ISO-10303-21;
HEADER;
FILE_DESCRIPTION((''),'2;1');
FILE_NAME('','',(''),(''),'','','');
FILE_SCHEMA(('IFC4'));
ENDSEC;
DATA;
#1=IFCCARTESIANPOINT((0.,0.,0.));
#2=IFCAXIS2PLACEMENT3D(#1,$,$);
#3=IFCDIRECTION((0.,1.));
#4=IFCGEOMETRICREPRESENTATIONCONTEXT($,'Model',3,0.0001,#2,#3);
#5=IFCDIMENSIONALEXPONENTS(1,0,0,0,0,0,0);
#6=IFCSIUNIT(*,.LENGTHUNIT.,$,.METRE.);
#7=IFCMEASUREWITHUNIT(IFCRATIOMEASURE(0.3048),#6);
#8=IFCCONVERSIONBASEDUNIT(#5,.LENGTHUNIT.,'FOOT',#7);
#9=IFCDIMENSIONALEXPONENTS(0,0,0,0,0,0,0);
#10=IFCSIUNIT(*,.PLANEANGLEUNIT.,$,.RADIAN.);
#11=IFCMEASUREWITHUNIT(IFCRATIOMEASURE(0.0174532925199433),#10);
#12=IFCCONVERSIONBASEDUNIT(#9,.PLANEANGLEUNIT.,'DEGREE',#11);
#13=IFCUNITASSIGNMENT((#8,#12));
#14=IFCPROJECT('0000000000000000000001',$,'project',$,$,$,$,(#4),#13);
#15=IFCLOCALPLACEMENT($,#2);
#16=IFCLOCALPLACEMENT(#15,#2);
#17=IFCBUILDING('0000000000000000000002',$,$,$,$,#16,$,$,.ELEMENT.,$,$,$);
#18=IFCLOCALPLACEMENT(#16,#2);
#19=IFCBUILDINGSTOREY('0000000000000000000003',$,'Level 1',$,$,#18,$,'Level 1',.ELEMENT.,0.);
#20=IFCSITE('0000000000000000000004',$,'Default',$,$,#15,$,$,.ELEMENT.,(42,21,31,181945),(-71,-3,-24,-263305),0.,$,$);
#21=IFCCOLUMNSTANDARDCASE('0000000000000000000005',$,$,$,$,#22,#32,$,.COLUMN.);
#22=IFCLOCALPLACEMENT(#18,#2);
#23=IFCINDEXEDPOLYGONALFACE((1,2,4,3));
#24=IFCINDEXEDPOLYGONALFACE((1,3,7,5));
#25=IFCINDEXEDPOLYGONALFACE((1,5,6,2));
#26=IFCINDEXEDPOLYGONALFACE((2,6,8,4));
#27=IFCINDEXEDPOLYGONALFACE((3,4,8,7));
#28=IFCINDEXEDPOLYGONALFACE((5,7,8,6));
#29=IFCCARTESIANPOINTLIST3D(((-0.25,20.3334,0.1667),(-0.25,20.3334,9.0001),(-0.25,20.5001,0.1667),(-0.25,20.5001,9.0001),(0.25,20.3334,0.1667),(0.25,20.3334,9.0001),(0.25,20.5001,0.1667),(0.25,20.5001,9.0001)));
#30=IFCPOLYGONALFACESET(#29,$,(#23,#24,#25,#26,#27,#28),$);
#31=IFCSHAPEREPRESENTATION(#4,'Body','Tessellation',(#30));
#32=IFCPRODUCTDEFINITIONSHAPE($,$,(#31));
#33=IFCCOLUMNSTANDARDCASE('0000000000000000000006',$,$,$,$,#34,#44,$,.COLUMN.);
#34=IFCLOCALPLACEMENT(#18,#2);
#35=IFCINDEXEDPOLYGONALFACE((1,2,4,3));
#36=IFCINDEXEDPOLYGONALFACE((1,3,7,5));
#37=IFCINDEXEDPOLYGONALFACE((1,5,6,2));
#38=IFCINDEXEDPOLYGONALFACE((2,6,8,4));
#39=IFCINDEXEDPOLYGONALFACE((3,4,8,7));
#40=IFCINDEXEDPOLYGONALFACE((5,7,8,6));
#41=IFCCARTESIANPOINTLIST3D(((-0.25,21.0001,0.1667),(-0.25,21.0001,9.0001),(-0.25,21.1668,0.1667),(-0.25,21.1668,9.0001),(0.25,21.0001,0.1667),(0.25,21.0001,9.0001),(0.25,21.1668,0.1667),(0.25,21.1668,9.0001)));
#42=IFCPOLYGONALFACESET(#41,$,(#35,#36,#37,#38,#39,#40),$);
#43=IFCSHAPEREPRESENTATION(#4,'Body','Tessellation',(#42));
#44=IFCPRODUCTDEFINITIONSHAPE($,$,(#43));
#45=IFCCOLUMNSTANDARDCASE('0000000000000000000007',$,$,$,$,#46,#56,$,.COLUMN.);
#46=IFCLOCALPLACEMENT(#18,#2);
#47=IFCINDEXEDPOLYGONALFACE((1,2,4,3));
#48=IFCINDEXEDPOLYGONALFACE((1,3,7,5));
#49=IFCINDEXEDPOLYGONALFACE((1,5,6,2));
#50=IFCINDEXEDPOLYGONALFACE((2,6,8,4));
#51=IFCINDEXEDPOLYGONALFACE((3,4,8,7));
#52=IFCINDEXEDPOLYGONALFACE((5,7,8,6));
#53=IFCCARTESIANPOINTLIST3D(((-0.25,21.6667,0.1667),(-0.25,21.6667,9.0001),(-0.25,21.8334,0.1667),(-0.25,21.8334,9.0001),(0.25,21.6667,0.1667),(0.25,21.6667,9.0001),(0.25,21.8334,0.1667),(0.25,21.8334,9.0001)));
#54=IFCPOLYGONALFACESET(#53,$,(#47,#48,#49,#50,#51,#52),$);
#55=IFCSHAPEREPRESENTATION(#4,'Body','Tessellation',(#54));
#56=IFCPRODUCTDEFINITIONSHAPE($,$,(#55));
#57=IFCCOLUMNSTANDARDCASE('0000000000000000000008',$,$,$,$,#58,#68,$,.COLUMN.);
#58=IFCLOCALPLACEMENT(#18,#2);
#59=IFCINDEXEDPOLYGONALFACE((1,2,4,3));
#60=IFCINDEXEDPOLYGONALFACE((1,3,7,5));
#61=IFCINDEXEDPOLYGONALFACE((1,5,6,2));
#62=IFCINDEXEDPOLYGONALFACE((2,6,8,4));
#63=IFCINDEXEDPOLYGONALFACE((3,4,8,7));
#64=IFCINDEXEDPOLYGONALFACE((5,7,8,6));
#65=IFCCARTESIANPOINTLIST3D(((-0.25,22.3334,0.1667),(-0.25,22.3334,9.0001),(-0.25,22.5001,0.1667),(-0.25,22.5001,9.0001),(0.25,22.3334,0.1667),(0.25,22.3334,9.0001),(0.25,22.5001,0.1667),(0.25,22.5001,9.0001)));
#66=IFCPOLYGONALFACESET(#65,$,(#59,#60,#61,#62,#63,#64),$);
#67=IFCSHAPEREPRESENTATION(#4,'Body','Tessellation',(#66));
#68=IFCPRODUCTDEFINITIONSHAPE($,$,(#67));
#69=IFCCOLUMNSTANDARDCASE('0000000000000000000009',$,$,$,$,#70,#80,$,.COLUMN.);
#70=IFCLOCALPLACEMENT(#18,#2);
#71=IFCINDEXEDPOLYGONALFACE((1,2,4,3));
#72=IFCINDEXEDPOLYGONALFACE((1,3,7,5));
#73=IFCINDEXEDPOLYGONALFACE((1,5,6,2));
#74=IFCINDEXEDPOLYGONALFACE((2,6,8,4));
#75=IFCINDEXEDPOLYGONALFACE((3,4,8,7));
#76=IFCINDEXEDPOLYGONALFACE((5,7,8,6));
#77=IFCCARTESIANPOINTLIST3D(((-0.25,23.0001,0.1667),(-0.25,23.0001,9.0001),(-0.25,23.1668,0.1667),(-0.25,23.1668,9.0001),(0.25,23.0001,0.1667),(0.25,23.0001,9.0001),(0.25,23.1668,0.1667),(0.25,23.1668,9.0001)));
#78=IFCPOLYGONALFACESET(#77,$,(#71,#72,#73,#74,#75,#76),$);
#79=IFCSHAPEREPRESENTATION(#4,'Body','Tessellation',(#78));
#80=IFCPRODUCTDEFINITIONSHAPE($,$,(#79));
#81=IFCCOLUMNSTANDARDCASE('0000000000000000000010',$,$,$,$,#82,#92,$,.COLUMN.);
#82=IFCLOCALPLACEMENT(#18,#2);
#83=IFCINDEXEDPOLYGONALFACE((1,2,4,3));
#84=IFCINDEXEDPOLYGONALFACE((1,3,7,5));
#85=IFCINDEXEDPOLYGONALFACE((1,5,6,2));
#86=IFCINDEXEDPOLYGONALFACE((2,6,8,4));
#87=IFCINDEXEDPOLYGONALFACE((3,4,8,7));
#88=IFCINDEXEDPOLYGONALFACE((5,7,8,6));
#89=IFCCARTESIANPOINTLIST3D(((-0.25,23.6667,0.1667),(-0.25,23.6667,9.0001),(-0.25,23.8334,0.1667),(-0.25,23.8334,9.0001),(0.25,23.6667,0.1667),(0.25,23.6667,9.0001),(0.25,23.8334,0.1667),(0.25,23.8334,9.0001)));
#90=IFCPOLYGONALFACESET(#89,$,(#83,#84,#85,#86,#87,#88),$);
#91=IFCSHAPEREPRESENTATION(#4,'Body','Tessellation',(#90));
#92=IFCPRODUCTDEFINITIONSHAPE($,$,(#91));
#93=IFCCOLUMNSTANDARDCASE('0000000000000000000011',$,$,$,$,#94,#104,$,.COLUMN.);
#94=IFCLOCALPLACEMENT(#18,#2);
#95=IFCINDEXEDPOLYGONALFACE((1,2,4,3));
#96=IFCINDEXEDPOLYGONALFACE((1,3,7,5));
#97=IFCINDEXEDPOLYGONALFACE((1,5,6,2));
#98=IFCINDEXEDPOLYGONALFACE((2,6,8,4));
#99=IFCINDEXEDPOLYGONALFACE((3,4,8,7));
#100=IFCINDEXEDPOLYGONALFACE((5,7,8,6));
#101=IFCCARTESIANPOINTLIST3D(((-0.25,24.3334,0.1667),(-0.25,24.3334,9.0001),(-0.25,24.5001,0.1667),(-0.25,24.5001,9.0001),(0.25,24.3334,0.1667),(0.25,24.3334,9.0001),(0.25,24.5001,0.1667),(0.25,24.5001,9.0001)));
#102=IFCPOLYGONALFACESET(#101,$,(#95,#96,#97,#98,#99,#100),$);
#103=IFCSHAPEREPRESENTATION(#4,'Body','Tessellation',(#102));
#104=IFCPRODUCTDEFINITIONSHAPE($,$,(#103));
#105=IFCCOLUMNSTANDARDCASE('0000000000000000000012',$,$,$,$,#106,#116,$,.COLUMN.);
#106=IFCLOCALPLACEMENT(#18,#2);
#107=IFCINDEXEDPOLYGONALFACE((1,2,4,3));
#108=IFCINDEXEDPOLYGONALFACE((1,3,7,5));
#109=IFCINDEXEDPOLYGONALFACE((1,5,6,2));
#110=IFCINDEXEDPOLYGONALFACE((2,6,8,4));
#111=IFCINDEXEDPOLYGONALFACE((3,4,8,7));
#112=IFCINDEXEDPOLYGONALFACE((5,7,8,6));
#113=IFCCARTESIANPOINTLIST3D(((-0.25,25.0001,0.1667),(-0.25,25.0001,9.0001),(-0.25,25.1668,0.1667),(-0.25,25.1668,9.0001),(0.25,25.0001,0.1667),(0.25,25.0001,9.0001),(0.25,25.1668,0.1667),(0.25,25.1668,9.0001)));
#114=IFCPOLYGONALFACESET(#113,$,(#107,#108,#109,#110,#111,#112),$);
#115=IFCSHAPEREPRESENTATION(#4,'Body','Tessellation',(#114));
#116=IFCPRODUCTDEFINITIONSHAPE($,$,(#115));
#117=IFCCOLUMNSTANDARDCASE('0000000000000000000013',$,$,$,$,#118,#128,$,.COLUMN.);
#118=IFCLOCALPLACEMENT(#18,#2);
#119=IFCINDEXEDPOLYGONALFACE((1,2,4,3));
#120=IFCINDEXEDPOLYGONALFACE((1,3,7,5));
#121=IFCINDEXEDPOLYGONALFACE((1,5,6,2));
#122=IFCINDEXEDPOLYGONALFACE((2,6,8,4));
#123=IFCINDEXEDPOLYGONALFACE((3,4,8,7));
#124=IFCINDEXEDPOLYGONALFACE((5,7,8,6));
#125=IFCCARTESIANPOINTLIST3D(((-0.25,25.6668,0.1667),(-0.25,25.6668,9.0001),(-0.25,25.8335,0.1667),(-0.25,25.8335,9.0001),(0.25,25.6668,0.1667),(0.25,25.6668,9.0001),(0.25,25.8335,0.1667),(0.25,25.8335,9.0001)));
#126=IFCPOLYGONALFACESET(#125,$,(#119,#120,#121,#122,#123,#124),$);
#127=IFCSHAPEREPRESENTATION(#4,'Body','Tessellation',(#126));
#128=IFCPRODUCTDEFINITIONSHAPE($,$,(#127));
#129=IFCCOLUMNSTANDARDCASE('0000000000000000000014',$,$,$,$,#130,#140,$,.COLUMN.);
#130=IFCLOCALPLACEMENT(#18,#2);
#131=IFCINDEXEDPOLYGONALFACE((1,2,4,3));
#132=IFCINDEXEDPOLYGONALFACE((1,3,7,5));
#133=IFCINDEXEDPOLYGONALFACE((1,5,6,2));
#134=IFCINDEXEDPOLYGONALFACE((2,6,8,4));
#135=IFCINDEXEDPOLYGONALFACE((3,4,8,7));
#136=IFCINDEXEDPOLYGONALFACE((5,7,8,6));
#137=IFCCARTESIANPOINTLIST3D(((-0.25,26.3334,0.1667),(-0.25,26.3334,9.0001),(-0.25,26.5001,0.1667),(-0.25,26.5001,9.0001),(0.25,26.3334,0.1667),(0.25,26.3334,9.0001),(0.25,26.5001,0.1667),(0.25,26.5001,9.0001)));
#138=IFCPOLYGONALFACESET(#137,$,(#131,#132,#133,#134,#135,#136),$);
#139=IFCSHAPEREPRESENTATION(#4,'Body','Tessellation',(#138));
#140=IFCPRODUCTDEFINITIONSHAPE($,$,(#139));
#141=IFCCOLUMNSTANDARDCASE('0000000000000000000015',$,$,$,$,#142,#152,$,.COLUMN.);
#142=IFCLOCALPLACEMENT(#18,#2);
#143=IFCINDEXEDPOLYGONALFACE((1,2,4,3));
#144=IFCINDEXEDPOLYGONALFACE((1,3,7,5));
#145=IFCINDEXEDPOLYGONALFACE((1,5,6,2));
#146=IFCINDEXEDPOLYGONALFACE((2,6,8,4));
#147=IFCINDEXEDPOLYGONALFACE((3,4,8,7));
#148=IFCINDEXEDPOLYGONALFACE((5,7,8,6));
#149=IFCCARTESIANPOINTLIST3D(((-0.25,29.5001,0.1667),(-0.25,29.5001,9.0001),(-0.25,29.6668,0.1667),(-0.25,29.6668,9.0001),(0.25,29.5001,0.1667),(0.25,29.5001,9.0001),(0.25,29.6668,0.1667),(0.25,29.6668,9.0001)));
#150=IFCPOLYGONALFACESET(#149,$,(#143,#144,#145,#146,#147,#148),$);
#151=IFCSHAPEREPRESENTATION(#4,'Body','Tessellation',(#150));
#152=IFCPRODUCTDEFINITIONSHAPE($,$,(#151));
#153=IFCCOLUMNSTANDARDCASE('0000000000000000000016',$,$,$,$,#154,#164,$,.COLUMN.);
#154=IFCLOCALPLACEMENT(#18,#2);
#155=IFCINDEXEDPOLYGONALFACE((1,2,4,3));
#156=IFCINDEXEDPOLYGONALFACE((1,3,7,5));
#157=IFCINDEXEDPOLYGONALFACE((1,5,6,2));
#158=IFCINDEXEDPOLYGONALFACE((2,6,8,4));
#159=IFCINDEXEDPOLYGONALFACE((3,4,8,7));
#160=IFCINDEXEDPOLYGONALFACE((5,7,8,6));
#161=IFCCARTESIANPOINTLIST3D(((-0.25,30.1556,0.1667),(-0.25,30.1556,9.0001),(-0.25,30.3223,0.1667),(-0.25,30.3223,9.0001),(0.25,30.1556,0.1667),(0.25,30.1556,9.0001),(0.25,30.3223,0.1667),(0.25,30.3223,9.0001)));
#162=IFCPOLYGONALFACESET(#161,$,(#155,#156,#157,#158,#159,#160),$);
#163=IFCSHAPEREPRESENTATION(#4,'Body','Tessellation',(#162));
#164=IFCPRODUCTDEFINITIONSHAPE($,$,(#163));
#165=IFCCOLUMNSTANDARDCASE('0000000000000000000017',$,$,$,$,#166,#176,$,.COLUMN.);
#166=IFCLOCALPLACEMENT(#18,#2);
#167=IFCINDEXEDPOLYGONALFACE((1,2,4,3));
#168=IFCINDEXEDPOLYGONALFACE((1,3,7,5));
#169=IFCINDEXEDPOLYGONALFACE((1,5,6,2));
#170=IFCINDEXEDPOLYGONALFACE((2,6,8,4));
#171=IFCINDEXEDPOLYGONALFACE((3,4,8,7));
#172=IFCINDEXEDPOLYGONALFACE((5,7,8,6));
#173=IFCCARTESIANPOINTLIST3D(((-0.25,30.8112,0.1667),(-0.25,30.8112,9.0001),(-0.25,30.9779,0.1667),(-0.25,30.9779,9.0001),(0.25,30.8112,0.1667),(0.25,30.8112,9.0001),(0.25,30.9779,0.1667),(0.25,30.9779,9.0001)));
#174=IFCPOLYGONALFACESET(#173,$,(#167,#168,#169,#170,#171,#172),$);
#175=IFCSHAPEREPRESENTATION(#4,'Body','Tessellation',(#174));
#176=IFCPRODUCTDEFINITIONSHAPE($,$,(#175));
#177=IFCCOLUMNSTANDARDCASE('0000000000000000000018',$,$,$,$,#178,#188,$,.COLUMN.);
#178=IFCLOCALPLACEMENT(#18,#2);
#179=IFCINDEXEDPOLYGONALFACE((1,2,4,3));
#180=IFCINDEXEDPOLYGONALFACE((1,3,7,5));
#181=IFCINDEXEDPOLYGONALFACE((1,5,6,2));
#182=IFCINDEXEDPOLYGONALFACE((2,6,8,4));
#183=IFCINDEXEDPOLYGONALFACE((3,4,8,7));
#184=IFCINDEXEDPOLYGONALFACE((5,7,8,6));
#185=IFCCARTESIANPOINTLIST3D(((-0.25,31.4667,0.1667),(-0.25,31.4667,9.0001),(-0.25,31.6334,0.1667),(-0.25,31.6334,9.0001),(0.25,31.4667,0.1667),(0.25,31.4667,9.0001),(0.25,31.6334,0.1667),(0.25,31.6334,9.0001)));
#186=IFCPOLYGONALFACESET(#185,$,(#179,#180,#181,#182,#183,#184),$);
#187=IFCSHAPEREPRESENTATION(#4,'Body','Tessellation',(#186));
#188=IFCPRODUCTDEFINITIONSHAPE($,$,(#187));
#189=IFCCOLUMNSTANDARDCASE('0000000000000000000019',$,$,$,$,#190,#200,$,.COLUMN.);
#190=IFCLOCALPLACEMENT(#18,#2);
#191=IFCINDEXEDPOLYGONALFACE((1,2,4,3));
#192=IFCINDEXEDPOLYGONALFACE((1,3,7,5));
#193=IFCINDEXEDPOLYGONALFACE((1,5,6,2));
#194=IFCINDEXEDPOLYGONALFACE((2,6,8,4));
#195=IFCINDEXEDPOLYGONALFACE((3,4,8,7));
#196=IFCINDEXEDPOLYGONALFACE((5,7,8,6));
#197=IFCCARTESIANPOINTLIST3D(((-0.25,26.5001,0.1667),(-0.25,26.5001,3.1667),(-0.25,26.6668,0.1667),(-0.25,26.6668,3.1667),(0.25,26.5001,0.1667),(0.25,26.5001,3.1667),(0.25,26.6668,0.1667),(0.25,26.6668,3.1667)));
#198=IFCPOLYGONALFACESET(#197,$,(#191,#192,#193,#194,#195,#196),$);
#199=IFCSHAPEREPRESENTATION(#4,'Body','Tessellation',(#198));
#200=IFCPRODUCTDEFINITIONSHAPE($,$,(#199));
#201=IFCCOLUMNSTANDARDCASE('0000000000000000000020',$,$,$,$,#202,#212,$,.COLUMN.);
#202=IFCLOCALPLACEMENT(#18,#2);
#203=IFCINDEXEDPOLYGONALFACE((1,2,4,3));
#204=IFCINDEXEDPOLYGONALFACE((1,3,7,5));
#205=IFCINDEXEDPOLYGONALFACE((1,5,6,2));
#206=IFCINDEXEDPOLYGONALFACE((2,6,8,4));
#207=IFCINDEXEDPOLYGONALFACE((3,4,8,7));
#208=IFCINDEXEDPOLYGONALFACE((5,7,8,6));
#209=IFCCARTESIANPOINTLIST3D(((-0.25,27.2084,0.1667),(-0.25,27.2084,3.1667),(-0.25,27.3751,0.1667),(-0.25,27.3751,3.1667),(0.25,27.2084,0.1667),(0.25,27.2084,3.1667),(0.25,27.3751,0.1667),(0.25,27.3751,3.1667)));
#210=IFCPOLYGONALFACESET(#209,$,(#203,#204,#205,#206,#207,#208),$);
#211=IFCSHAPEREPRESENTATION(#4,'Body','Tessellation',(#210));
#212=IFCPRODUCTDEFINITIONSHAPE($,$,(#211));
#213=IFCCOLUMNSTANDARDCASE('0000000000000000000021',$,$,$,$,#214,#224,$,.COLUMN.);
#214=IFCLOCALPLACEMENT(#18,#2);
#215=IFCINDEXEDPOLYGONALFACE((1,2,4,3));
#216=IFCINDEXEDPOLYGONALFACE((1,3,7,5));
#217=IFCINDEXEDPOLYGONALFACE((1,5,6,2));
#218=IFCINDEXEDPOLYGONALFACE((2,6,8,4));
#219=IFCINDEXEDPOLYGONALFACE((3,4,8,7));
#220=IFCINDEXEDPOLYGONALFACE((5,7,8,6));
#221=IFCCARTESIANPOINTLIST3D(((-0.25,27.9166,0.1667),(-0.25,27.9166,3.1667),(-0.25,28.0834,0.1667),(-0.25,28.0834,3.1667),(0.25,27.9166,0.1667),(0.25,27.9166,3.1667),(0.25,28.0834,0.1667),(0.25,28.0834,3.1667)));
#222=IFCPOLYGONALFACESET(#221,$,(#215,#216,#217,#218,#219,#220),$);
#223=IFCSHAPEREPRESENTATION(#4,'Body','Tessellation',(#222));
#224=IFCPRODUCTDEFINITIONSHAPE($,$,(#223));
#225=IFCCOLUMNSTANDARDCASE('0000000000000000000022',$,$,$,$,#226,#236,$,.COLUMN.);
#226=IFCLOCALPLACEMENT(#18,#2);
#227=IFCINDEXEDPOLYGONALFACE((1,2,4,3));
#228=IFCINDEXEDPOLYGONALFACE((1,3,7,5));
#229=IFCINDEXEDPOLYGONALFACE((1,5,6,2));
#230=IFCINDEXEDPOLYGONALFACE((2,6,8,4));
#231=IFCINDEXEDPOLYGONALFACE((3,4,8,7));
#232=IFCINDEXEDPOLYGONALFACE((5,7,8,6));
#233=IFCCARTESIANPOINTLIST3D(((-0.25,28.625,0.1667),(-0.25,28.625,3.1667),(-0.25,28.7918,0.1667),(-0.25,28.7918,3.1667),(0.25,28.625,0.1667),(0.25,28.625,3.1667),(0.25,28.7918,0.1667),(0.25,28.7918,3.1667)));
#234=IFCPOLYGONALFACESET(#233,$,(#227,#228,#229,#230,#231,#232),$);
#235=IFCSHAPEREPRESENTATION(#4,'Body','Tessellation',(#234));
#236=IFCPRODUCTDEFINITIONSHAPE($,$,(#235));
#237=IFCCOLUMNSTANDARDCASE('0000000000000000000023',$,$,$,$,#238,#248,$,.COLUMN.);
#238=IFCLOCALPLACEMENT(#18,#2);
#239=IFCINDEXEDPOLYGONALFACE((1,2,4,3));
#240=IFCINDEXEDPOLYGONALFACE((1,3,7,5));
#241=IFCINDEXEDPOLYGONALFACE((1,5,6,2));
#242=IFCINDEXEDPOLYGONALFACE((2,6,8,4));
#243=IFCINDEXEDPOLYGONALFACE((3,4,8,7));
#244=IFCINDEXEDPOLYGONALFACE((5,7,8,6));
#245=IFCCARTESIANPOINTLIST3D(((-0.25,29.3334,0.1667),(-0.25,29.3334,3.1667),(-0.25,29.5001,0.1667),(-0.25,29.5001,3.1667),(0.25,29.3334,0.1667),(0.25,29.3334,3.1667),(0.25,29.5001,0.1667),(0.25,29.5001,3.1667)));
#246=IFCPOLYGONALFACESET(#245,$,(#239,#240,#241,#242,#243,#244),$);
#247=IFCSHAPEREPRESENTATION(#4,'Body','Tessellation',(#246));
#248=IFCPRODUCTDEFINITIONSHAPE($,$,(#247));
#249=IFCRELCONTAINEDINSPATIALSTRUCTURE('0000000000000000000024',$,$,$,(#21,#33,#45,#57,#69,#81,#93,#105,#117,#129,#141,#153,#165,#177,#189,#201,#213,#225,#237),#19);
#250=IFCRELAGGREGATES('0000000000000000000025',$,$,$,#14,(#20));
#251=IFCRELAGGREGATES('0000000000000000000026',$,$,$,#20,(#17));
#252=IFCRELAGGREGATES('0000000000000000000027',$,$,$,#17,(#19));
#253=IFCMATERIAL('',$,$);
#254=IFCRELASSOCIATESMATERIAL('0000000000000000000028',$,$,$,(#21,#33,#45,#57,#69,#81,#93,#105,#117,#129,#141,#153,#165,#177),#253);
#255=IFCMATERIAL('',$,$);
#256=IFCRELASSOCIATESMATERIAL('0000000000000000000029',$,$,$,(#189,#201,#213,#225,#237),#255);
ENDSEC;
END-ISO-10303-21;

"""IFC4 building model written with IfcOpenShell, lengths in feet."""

from ifc_helpers import new_model, entity, si_unit, converted_unit, direction, frame, origin, place, context, project, spatial, rectangle, extrude, material, element, save


model = new_model("IFC4")

# Units and contexts
model_context = context("Model", 3, precision=0.0001, world=origin(), true_north=direction((0.0, 1.0)))
ifc_project = project(units=[converted_unit("LENGTHUNIT", "FOOT", entity("IfcRatioMeasure", 0.3048), si_unit("LENGTHUNIT", "METRE"), dimensions=[1, 0, 0, 0, 0, 0, 0]), converted_unit("PLANEANGLEUNIT", "DEGREE", entity("IfcRatioMeasure", 0.0174532925199433), si_unit("PLANEANGLEUNIT", "RADIAN"), dimensions=[0, 0, 0, 0, 0, 0, 0])], contexts=[model_context])

# Site, building, storey
site_placement = place(None, origin())
site = spatial("IfcSite", under=ifc_project, at=site_placement, Name="Default", CompositionType="ELEMENT", RefLatitude=(42, 21, 31, 181945), RefLongitude=(-71, -3, -24, -263305), RefElevation=0.0)
building_placement = place(site_placement, origin())
building = spatial("IfcBuilding", under=site, at=building_placement, CompositionType="ELEMENT")
storey_placement = place(building_placement, origin())
storey = spatial("IfcBuildingStorey", under=building, at=storey_placement, Name="Level 1", LongName="Level 1", CompositionType="ELEMENT", Elevation=0.0)

# Columns
ifc_material_1 = material(Name="")
placement_1 = place(storey_placement, frame((0.0, -0.25, 0.0), z_axis=(0.0, 0.0, 1.0), x_axis=(0.0, 1.0, 0.0)))
for number, where, z_axis, x_axis in (
    (1, (20.6667, 0.0, 0.1667), (0.0, 0.0, 1.0), (1.0, 0.0, 0.0)),
    (2, (21.3334, 0.0, 0.1667), (0.0, 0.0, 1.0), (1.0, 0.0, 0.0)),
    (3, (22.0, 0.0, 0.1667), (0.0, 0.0, 1.0), (1.0, 0.0, 0.0)),
    (4, (22.6667, 0.0, 0.1667), (0.0, 0.0, 1.0), (1.0, 0.0, 0.0)),
    (5, (23.3334, 0.0, 0.1667), (0.0, 0.0, 1.0), (1.0, 0.0, 0.0)),
    (6, (24.0, 0.0, 0.1667), (0.0, 0.0, 1.0), (1.0, 0.0, 0.0)),
    (7, (24.6667, 0.0, 0.1667), (0.0, 0.0, 1.0), (1.0, 0.0, 0.0)),
    (8, (25.3334, 0.0, 0.1667), (0.0, 0.0, 1.0), (1.0, 0.0, 0.0)),
    (9, (26.0001, 0.0, 0.1667), (0.0, 0.0, 1.0), (1.0, 0.0, 0.0)),
    (10, (26.6667, 0.0, 0.1667), (0.0, 0.0, 1.0), (1.0, 0.0, 0.0)),
    (11, (29.8334, 0.0, 0.1667), (0.0, 0.0, 1.0), (1.0, 0.0, 0.0)),
    (12, (30.4889, 0.0, 0.1667), (0.0, 0.0, 1.0), (1.0, 0.0, 0.0)),
    (13, (31.1445, 0.0, 0.1667), (0.0, 0.0, 1.0), (1.0, 0.0, 0.0)),
    (14, (31.8, 0.0, 0.1667), (0.0, 0.0, 1.0), (1.0, 0.0, 0.0)),
):
    element("IfcColumnStandardCase", number, at=place(placement_1, frame(where, z_axis=z_axis, x_axis=x_axis)), inside=storey, material=ifc_material_1, PredefinedType="COLUMN", context=model_context, shape_type="SweptSolid", body=[
        extrude(rectangle(XDim=0.1667, YDim=0.5), origin(), (0.0, 0.0, 1.0), 8.8334),
    ])
ifc_material_2 = material(Name="")
for number, where, z_axis, x_axis in (
    (15, (26.8334, 0.0, 0.1667), (0.0, 0.0, 1.0), (1.0, 0.0, 0.0)),
    (16, (27.5417, 0.0, 0.1667), (0.0, 0.0, 1.0), (1.0, 0.0, 0.0)),
    (17, (28.25, 0.0, 0.1667), (0.0, 0.0, 1.0), (1.0, 0.0, 0.0)),
    (18, (28.9584, 0.0, 0.1667), (0.0, 0.0, 1.0), (1.0, 0.0, 0.0)),
    (19, (29.6667, 0.0, 0.1667), (0.0, 0.0, 1.0), (1.0, 0.0, 0.0)),
):
    element("IfcColumnStandardCase", number, at=place(placement_1, frame(where, z_axis=z_axis, x_axis=x_axis)), inside=storey, material=ifc_material_2, PredefinedType="COLUMN", context=model_context, shape_type="SweptSolid", body=[
        extrude(rectangle(XDim=0.1667, YDim=0.5), origin(), (0.0, 0.0, 1.0), 3.0),
    ])

save(model, "model.ifc")
